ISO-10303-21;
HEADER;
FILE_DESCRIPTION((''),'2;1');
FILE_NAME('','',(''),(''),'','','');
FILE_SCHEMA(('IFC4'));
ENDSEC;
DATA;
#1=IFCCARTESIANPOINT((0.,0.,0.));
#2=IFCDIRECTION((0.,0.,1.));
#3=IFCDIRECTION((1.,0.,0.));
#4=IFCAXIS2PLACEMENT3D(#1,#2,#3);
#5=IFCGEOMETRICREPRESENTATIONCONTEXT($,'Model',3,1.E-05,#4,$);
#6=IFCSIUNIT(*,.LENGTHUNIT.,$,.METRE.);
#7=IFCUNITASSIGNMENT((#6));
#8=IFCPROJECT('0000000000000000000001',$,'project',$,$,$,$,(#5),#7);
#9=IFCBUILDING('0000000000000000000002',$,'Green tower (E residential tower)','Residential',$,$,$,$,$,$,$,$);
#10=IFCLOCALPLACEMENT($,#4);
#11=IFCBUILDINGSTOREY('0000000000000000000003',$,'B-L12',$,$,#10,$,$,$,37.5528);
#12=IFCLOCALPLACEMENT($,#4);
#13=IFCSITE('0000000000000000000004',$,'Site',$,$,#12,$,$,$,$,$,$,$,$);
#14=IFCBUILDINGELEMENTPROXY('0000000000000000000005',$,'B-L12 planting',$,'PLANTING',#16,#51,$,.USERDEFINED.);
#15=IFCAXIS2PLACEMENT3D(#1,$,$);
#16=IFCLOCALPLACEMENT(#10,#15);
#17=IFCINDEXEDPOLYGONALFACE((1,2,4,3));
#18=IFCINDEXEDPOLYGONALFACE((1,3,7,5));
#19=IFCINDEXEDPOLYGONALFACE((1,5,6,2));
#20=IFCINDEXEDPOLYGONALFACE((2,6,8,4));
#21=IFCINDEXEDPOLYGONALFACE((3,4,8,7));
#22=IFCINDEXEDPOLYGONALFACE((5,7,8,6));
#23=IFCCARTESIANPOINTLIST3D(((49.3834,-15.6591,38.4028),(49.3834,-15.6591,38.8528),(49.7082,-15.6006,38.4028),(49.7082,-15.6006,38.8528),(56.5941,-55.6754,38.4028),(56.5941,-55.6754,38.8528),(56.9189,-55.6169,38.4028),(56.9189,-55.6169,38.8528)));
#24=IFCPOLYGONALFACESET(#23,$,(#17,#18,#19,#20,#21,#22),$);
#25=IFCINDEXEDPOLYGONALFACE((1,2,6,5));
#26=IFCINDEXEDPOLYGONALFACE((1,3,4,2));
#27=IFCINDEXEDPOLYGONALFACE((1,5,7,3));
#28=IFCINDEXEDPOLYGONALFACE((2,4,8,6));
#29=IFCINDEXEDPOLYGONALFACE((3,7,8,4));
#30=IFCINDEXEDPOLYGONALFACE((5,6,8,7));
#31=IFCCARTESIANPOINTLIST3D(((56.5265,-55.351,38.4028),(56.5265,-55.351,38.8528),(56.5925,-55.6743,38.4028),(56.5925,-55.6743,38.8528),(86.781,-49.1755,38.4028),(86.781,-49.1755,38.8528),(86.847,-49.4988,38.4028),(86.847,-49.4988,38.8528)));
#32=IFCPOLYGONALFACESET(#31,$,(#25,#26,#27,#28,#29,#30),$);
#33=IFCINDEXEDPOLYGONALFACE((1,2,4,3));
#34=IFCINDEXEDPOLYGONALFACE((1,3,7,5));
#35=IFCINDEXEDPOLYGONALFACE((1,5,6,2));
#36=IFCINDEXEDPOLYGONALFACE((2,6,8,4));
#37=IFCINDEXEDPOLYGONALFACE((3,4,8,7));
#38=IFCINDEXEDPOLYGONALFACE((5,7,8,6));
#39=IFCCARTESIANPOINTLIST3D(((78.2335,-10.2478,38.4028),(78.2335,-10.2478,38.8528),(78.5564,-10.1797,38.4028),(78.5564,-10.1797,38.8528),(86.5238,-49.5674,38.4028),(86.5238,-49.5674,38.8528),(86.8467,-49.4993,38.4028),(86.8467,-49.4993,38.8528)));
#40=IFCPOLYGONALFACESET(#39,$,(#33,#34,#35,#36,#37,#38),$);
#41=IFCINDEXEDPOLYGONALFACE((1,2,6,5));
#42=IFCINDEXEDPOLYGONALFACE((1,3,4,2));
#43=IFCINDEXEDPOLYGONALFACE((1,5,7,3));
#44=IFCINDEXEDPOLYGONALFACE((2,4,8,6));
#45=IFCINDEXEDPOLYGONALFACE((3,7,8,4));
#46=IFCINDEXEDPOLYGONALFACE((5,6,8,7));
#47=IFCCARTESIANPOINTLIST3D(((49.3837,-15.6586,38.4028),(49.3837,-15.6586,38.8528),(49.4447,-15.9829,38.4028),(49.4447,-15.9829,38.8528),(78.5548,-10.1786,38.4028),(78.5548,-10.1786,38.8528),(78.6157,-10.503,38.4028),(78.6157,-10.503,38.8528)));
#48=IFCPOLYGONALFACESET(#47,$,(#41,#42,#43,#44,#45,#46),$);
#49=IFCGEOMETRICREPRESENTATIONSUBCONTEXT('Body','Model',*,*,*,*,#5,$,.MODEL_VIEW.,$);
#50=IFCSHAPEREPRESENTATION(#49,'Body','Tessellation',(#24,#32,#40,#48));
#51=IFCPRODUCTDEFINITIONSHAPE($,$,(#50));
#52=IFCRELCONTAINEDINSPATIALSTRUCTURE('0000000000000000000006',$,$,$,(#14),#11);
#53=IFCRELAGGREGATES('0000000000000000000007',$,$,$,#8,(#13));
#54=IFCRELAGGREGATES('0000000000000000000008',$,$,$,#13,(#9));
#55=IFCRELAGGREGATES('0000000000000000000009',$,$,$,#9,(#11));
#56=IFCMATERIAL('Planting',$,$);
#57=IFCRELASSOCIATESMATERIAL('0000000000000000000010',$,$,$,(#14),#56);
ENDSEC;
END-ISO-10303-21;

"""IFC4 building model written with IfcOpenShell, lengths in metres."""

from ifc_helpers import new_model, si_unit, frame, origin_with_axes, place, context, subcontext, project, spatial, polyline, outline, extrude, material, element, save


model = new_model("IFC4")

# Units and contexts
model_context = context("Model", 3, precision=1e-05, world=origin_with_axes())
body_context = subcontext(model_context, "Body", "Model", "MODEL_VIEW")
ifc_project = project(units=[si_unit("LENGTHUNIT", "METRE")], contexts=[model_context])

# Site, building, storey
site_placement = place(None, origin_with_axes())
site = spatial("IfcSite", under=ifc_project, at=site_placement, Name="Site")
building = spatial("IfcBuilding", under=site, Name="Green tower (E residential tower)", Description="Residential")
storey_placement = place(None, origin_with_axes())
storey = spatial("IfcBuildingStorey", under=building, at=storey_placement, Name="B-L12", Elevation=37.5528)

# Building element proxy
ifc_material_1 = material(Name="Planting")
proxy_1_placement = place(storey_placement, origin_with_axes())
element("IfcBuildingElementProxy", 1, at=proxy_1_placement, inside=storey, material=ifc_material_1, Name="B-L12 planting", ObjectType="PLANTING", PredefinedType="USERDEFINED", context=body_context, shape_type="SweptSolid", body=[
    extrude(outline(polyline([(49.3834, -15.6591), (56.5941, -55.6754), (56.9189, -55.6169), (49.7082, -15.6006), (49.3834, -15.6591)])), frame((0.0, 0.0, 38.4028), z_axis=(0.0, 0.0, 1.0), x_axis=(1.0, 0.0, 0.0)), (0.0, 0.0, 1.0), 0.45),
    extrude(outline(polyline([(56.5925, -55.6743), (86.847, -49.4988), (86.781, -49.1755), (56.5265, -55.351), (56.5925, -55.6743)])), frame((0.0, 0.0, 38.4028), z_axis=(0.0, 0.0, 1.0), x_axis=(1.0, 0.0, 0.0)), (0.0, 0.0, 1.0), 0.45),
    extrude(outline(polyline([(86.8467, -49.4993), (78.5564, -10.1797), (78.2335, -10.2478), (86.5238, -49.5674), (86.8467, -49.4993)])), frame((0.0, 0.0, 38.4028), z_axis=(0.0, 0.0, 1.0), x_axis=(1.0, 0.0, 0.0)), (0.0, 0.0, 1.0), 0.45),
    extrude(outline(polyline([(78.5548, -10.1786), (49.3837, -15.6586), (49.4447, -15.9829), (78.6157, -10.503), (78.5548, -10.1786)])), frame((0.0, 0.0, 38.4028), z_axis=(0.0, 0.0, 1.0), x_axis=(1.0, 0.0, 0.0)), (0.0, 0.0, 1.0), 0.45),
])

save(model, "model.ifc")
